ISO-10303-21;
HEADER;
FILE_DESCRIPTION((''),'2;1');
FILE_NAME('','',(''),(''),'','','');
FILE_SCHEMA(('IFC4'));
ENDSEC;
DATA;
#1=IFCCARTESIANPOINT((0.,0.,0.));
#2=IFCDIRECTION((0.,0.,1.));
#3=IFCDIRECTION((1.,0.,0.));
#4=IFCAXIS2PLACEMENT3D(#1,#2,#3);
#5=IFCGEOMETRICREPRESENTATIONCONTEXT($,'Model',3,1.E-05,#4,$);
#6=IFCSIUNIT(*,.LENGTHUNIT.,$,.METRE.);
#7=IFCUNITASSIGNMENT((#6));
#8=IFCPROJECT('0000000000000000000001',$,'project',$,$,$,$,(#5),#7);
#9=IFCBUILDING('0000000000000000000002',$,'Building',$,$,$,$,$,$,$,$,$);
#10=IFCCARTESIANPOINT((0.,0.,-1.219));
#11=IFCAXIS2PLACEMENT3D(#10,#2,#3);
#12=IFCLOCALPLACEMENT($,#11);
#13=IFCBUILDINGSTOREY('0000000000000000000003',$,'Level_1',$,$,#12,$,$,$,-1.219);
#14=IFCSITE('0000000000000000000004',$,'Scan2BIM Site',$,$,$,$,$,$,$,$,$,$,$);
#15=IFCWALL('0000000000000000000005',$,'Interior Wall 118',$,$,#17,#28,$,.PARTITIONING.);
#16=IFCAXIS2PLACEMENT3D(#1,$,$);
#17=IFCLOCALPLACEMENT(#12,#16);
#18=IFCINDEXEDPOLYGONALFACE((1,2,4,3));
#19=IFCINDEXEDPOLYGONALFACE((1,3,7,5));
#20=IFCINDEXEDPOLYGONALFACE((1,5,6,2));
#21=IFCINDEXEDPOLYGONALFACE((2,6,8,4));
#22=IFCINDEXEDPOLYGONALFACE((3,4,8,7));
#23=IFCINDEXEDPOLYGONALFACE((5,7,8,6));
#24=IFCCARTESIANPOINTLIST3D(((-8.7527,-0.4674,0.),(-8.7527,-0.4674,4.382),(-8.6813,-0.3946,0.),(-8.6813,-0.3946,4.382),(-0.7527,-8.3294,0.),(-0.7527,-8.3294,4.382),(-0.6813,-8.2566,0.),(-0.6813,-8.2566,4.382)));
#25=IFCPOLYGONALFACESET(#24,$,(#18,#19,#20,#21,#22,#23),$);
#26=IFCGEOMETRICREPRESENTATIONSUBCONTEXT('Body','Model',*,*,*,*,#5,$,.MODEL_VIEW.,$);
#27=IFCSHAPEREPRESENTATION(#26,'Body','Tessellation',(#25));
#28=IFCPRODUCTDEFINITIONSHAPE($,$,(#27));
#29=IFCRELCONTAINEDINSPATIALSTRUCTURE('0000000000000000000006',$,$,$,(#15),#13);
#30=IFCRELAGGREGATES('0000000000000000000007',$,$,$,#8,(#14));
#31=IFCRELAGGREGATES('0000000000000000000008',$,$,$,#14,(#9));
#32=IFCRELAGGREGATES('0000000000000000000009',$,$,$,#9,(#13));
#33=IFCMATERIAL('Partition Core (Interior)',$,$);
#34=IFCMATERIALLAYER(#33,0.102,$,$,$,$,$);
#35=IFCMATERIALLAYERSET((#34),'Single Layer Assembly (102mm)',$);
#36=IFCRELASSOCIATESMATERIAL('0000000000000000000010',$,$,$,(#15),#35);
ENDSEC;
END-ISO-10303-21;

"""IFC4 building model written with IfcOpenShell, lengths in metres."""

from ifc_helpers import new_model, si_unit, frame, origin, origin_with_axes, place, context, subcontext, project, spatial, rectangle, extrude, material, layer, layer_set, element, save


model = new_model("IFC4")

# Units and contexts
model_context = context("Model", 3, precision=1e-05, world=origin_with_axes())
body_context = subcontext(model_context, "Body", "Model", "MODEL_VIEW")
ifc_project = project(units=[si_unit("LENGTHUNIT", "METRE")], contexts=[model_context])

# Site, building, storey
site = spatial("IfcSite", under=ifc_project, Name="Scan2BIM Site")
building = spatial("IfcBuilding", under=site, Name="Building")
storey_placement = place(None, frame((0.0, 0.0, -1.219), z_axis=(0.0, 0.0, 1.0), x_axis=(1.0, 0.0, 0.0)))
storey = spatial("IfcBuildingStorey", under=building, at=storey_placement, Name="Level_1", Elevation=-1.219)

# Wall
ifc_material_1 = material(Name="Partition Core (Interior)")
ifc_layer_1 = layer(ifc_material_1, 0.102)
ifc_layer_set_1 = layer_set([ifc_layer_1], Name="Single Layer Assembly (102mm)")
wall_1_placement = place(storey_placement, frame((-4.717, -4.362, 0.0), z_axis=(0.0, 0.0, 1.0), x_axis=(0.713232, -0.700928, 0.0)))
element("IfcWall", 1, at=wall_1_placement, inside=storey, material=ifc_layer_set_1, Name="Interior Wall 118", PredefinedType="PARTITIONING", context=body_context, shape_type="SweptSolid", body=[
    extrude(rectangle(XDim=11.2166, YDim=0.102), origin(), (0.0, 0.0, 1.0), 4.382),
])

save(model, "model.ifc")
